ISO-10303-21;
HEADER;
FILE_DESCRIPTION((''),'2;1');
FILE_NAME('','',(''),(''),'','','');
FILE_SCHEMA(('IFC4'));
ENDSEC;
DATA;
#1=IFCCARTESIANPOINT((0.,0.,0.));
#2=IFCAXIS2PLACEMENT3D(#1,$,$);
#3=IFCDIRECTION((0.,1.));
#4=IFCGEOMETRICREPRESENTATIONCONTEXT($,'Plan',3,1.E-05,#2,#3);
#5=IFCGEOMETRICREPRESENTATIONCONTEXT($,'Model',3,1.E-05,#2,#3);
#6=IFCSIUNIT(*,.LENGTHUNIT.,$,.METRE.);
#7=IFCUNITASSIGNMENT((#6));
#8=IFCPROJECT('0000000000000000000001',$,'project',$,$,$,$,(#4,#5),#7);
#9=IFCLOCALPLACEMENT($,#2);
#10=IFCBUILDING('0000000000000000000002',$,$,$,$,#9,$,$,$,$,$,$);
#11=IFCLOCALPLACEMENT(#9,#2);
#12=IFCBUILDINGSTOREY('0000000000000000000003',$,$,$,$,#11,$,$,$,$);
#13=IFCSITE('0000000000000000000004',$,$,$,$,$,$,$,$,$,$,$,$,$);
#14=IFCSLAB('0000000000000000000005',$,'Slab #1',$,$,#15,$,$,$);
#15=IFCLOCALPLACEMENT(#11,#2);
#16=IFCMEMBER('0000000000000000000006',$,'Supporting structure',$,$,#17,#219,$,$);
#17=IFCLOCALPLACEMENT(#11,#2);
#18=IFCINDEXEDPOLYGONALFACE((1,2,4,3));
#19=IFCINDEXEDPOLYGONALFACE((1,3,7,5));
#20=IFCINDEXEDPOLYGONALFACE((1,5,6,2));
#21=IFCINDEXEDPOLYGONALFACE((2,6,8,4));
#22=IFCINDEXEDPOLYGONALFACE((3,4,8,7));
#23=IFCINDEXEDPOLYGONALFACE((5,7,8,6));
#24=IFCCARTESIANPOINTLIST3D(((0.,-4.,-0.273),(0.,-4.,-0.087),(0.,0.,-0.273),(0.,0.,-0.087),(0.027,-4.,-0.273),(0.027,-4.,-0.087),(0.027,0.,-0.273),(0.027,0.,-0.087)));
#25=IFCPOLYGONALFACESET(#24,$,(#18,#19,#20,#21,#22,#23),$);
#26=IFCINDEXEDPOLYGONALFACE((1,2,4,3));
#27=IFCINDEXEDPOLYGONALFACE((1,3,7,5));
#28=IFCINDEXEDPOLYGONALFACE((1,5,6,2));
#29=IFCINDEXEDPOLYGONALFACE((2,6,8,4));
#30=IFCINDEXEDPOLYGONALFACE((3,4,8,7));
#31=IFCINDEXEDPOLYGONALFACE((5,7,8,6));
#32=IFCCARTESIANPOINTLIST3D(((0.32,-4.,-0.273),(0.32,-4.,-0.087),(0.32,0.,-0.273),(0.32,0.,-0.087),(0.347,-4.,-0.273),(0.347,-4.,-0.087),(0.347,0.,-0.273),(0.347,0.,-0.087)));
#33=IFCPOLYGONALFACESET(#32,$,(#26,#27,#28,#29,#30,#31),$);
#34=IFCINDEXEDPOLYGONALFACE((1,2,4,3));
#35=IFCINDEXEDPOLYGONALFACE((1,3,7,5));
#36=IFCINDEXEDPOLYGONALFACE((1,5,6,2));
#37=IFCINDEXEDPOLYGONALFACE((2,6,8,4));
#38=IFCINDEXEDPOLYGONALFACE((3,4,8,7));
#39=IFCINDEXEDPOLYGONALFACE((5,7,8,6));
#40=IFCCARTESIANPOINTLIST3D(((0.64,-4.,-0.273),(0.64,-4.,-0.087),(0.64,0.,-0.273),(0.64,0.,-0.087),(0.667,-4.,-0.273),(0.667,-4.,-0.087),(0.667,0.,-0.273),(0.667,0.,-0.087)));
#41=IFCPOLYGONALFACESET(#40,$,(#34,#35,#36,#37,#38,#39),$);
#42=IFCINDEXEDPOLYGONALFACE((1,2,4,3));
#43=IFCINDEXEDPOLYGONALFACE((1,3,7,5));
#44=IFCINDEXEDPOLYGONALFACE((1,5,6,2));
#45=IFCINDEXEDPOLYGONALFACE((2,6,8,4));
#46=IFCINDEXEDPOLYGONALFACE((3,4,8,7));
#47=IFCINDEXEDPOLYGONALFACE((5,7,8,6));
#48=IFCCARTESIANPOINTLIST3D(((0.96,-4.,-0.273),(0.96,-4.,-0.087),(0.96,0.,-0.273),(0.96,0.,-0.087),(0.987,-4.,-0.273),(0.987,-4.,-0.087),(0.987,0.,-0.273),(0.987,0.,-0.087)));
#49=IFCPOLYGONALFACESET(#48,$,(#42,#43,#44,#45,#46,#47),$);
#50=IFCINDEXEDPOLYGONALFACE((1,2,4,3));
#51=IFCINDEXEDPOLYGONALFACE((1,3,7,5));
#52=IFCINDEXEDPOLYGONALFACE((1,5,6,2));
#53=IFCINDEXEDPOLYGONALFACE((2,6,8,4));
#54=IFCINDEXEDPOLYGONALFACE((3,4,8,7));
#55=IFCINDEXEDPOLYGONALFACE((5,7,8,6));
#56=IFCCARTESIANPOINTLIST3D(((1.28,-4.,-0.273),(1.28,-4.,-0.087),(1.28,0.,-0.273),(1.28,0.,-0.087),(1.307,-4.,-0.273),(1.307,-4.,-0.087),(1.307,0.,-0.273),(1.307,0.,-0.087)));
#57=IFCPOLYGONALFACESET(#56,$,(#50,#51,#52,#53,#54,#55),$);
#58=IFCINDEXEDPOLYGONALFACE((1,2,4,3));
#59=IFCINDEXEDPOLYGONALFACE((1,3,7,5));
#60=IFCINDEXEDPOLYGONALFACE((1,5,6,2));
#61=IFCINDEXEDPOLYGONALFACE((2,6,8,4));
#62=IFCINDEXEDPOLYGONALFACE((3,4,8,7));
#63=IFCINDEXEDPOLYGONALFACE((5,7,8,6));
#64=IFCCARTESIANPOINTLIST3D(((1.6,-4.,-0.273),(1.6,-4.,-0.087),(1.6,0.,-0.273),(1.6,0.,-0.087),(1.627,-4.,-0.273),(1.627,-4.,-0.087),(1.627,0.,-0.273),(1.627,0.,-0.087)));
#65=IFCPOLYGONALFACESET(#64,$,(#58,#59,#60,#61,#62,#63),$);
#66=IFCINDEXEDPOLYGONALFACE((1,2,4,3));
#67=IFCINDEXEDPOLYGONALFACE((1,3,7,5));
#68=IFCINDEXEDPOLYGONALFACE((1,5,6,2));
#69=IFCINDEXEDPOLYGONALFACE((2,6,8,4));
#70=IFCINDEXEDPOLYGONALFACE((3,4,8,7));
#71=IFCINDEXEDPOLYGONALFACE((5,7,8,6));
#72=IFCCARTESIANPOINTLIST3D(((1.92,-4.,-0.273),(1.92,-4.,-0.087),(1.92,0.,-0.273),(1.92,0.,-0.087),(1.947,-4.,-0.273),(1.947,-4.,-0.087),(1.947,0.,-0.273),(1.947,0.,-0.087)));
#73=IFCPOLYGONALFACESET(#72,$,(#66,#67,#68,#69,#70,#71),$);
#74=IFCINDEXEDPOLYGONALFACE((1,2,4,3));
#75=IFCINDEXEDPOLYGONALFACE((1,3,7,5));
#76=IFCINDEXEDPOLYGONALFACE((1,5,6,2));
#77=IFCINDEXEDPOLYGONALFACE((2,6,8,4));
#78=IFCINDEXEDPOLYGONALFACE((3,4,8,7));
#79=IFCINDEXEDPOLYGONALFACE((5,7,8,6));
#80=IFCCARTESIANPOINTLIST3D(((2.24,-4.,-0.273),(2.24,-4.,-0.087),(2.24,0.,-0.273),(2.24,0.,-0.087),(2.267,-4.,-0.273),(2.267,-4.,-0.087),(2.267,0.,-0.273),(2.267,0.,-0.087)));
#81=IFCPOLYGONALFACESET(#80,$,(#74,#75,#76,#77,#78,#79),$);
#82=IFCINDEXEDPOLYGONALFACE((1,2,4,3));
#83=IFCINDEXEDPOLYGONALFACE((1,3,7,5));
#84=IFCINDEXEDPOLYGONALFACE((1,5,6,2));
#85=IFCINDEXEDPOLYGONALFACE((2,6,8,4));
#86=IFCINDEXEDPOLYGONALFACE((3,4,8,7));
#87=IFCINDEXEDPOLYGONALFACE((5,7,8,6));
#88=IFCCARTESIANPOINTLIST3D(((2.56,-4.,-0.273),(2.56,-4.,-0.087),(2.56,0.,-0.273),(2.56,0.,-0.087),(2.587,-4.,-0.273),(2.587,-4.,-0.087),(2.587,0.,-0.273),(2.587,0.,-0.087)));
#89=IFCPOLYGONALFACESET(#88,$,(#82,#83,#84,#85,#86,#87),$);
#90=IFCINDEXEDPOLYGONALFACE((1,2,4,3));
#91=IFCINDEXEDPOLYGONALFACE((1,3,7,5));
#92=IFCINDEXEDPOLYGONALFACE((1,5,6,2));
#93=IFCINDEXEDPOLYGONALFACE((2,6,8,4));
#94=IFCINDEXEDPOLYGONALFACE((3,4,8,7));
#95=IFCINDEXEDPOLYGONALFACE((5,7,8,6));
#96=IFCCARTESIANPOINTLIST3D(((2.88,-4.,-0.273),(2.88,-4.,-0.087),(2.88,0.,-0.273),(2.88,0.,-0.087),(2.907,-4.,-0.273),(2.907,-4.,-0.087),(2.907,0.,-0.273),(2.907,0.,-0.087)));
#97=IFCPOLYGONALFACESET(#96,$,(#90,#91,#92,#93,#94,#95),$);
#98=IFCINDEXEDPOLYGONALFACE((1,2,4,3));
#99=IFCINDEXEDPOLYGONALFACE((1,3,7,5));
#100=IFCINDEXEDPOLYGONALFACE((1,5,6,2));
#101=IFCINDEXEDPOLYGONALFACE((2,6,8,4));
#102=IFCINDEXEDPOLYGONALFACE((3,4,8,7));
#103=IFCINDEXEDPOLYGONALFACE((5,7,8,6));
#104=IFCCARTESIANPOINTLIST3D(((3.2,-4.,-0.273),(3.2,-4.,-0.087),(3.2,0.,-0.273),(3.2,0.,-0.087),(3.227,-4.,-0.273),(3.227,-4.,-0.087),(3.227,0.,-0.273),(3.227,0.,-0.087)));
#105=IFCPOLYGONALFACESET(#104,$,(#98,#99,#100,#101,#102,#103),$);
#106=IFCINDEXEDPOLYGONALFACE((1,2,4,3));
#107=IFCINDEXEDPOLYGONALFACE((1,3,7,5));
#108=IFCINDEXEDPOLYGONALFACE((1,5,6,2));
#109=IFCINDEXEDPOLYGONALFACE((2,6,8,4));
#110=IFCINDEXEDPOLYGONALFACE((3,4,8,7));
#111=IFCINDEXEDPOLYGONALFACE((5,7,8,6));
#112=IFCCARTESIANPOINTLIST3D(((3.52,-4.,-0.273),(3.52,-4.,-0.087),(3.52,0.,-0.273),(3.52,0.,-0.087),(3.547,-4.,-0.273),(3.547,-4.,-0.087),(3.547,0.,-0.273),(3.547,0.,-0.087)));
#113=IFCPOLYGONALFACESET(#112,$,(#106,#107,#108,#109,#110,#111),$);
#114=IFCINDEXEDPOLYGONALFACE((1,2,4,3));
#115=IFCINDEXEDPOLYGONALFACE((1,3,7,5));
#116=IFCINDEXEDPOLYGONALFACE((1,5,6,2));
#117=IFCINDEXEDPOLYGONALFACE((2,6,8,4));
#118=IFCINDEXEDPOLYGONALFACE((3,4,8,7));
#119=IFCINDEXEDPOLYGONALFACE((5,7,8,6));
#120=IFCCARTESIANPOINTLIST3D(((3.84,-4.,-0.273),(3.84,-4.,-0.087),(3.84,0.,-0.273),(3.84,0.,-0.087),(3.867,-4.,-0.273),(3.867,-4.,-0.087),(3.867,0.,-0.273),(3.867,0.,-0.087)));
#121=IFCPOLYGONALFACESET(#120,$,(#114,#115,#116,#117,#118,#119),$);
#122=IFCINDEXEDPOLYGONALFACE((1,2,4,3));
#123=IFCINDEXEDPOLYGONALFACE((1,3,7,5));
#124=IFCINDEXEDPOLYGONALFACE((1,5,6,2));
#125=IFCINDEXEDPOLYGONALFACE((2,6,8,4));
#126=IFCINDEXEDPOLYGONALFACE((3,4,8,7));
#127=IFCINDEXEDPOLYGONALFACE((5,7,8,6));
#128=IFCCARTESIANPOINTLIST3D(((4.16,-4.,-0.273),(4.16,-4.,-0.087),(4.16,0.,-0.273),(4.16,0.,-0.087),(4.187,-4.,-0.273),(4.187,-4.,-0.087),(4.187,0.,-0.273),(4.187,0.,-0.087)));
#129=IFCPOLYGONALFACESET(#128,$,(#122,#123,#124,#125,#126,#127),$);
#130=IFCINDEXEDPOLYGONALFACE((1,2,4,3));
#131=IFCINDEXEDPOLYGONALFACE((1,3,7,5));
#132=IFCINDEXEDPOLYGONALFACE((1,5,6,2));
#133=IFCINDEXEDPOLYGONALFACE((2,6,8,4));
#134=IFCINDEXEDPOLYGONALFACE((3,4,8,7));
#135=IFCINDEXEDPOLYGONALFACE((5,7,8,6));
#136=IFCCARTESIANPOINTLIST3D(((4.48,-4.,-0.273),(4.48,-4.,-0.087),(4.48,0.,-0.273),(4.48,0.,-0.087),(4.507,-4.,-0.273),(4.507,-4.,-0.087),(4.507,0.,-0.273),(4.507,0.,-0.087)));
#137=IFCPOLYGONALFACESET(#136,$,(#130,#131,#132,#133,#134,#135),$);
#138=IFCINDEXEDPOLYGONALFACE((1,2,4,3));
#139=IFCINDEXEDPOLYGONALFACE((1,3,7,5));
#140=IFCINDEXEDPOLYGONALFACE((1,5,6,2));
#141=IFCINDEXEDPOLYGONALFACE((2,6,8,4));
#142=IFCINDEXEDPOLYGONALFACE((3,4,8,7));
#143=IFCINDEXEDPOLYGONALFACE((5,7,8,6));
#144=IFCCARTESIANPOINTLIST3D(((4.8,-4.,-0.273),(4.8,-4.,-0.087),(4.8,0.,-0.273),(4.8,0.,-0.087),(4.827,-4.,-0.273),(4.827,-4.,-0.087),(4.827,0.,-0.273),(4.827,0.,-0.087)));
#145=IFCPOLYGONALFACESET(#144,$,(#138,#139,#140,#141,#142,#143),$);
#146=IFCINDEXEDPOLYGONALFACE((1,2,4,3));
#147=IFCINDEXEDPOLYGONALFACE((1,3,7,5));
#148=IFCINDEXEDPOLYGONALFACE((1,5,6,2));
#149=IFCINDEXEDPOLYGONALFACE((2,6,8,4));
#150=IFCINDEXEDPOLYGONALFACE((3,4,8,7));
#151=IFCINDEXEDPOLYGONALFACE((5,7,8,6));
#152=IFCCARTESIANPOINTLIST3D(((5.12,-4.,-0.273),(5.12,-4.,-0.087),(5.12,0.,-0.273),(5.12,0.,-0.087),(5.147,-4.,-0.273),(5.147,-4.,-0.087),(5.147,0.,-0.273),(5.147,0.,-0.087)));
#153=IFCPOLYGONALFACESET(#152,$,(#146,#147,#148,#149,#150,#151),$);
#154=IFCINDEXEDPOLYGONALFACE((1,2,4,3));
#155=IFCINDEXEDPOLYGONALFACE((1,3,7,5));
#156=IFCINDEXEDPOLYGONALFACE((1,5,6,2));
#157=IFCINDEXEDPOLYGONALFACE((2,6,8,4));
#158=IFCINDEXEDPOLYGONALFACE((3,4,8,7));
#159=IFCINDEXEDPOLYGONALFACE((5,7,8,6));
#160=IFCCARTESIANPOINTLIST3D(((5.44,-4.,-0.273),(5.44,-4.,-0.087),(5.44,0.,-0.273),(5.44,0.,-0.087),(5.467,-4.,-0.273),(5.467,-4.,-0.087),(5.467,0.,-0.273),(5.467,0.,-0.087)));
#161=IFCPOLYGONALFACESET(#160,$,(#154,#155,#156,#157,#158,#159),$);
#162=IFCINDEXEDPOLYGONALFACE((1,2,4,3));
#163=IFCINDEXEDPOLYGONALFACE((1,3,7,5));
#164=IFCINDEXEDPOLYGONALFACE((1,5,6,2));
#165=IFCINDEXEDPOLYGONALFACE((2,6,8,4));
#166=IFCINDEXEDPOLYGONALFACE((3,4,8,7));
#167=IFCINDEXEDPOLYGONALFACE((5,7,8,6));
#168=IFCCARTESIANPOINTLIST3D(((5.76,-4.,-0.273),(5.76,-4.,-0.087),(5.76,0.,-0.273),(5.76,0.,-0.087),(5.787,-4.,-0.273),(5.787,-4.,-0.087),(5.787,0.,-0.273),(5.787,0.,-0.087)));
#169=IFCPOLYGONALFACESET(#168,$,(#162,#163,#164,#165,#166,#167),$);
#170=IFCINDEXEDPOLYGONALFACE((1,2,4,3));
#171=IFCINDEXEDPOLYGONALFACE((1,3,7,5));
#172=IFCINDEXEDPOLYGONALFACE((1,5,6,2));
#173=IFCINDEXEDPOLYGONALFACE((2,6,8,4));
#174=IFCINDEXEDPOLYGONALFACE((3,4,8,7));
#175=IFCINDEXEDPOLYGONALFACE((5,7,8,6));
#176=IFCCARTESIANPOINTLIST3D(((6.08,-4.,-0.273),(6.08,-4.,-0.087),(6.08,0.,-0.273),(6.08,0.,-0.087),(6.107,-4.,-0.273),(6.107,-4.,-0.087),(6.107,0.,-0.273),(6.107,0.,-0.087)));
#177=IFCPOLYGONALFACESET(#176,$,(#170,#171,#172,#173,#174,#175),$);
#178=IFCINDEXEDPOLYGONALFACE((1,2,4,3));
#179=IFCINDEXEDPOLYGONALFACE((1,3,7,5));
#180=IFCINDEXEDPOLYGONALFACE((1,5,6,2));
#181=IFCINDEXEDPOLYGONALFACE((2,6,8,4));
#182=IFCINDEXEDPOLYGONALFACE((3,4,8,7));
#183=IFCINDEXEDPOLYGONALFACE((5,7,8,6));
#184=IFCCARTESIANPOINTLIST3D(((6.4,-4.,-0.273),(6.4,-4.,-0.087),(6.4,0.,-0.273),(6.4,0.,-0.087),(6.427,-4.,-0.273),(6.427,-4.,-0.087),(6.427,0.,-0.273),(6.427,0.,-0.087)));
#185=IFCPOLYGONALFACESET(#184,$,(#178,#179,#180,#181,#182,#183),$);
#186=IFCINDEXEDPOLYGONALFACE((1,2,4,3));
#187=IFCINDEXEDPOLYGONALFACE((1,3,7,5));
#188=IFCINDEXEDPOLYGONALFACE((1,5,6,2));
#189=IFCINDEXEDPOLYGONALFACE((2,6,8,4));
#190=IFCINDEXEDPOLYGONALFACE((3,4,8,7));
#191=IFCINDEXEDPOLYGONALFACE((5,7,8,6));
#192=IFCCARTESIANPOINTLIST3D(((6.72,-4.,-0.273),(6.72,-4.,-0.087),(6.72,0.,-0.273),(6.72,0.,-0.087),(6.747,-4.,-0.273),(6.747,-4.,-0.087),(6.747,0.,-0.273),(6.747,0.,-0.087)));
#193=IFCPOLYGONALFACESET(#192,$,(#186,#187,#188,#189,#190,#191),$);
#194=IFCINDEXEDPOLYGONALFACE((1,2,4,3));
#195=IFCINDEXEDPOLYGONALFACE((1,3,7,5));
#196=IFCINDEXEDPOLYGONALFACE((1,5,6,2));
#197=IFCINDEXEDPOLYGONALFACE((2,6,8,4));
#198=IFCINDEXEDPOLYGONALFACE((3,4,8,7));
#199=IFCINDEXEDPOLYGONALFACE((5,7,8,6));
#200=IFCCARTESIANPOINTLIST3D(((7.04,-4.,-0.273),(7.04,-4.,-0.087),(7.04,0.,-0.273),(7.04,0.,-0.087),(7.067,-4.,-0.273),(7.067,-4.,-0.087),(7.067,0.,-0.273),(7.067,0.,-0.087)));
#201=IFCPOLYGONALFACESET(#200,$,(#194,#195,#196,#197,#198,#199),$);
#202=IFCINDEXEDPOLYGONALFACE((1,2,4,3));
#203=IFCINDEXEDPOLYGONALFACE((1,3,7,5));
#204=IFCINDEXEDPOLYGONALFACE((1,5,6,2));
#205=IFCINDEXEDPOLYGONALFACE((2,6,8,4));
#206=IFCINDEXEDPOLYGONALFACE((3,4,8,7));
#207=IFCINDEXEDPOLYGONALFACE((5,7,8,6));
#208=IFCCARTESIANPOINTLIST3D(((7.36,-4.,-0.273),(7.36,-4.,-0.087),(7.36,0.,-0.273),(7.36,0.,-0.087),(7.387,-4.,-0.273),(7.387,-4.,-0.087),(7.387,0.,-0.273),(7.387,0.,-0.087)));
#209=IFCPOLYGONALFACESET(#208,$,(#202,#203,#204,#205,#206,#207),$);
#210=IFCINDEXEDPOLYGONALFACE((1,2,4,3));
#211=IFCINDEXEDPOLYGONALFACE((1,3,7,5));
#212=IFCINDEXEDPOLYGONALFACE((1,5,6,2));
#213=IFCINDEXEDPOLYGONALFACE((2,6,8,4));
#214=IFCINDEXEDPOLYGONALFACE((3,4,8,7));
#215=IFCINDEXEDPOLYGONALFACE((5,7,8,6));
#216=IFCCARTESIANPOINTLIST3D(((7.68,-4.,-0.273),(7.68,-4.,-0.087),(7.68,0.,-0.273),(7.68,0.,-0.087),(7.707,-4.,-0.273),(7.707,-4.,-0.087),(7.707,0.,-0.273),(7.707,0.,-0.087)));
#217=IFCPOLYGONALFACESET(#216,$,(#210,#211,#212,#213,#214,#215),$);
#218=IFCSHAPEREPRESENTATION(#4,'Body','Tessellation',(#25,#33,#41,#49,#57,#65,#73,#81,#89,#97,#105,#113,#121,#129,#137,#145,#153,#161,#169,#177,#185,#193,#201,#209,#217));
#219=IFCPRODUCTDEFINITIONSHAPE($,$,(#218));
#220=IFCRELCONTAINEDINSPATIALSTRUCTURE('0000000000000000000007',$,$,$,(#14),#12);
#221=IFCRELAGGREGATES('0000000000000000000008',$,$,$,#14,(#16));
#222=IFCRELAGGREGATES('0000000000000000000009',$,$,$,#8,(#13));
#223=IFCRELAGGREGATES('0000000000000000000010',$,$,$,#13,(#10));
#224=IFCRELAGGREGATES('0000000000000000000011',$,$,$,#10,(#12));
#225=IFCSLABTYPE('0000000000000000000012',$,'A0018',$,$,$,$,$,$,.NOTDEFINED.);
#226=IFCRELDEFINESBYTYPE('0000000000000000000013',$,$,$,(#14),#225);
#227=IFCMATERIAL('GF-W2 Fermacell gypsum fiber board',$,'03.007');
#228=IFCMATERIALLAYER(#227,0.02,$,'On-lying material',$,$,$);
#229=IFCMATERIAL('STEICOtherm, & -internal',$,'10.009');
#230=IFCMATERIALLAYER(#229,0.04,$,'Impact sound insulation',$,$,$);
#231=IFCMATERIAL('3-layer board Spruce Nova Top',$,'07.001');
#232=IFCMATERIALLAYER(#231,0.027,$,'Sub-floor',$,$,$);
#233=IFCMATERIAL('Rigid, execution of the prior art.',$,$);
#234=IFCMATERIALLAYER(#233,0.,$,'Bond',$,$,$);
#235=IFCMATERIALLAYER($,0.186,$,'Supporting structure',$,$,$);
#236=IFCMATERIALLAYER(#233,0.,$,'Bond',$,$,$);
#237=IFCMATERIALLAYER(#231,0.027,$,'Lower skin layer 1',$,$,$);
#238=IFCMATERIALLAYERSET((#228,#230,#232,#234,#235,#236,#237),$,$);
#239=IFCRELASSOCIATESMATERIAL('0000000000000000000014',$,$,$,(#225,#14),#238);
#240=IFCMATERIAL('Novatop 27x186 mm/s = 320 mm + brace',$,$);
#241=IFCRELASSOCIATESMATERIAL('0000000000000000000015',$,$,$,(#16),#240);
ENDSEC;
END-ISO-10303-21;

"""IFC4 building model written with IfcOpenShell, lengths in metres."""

from ifc_helpers import new_model, si_unit, direction, frame, frame_2d, origin, place, context, project, spatial, rectangle, extrude, material, layer, layer_set, type_object, element, aggregate, save


model = new_model("IFC4")

# Units and contexts
plan_context = context("Plan", 3, precision=1e-05, world=origin(), true_north=direction((0.0, 1.0)))
model_context = context("Model", 3, precision=1e-05, world=origin(), true_north=direction((0.0, 1.0)))
ifc_project = project(units=[si_unit("LENGTHUNIT", "METRE")], contexts=[plan_context, model_context])

# Site, building, storey
site = spatial("IfcSite", under=ifc_project)
building_placement = place(None, origin())
building = spatial("IfcBuilding", under=site, at=building_placement)
storey_placement = place(building_placement, origin())
storey = spatial("IfcBuildingStorey", under=building, at=storey_placement)

# Slab, member
ifc_material_1 = material(Name="GF-W2 Fermacell gypsum fiber board", Category="03.007")
ifc_layer_1 = layer(ifc_material_1, 0.02, Name="On-lying material")
ifc_material_2 = material(Name="STEICOtherm, & -internal", Category="10.009")
ifc_layer_2 = layer(ifc_material_2, 0.04, Name="Impact sound insulation")
ifc_material_3 = material(Name="3-layer board Spruce Nova Top", Category="07.001")
ifc_layer_3 = layer(ifc_material_3, 0.027, Name="Sub-floor")
ifc_material_4 = material(Name="Rigid, execution of the prior art.")
ifc_layer_4 = layer(ifc_material_4, 0.0, Name="Bond")
ifc_layer_5 = layer(None, 0.186, Name="Supporting structure")
ifc_layer_6 = layer(ifc_material_4, 0.0, Name="Bond")
ifc_layer_7 = layer(ifc_material_3, 0.027, Name="Lower skin layer 1")
ifc_layer_set = layer_set([ifc_layer_1, ifc_layer_2, ifc_layer_3, ifc_layer_4, ifc_layer_5, ifc_layer_6, ifc_layer_7])
slab_type = type_object("IfcSlabType", Name="A0018", PredefinedType="NOTDEFINED", material=ifc_layer_set)
slab_placement = place(None, frame((0.0, 0.0, 0.0), z_axis=(0.0, 0.0, -1.0), x_axis=(1.0, 0.0, 0.0)))
slab = element("IfcSlab", 1, at=slab_placement, inside=storey, type_object=slab_type, material=ifc_layer_set, Name="Slab #1")
ifc_material_5 = material(Name="Novatop 27x186 mm/s = 320 mm + brace")
member_1_placement = place(slab_placement, origin())
member_1 = element("IfcMember", 2, at=member_1_placement, material=ifc_material_5, Name="Supporting structure", context=plan_context, shape_type="SweptSolid", body=[
    extrude(rectangle(XDim=0.027, YDim=0.186, at=frame_2d((0.0135, 0.093), x_axis=(1.0, 0.0))), frame((0.0, 4.0, 0.087), z_axis=(0.0, -1.0, 0.0), x_axis=(1.0, 0.0, 0.0)), (0.0, 0.0, 1.0), 4.0),
    extrude(rectangle(XDim=0.027, YDim=0.186, at=frame_2d((0.0135, 0.093), x_axis=(1.0, 0.0))), frame((0.32, 4.0, 0.087), z_axis=(0.0, -1.0, 0.0), x_axis=(1.0, 0.0, 0.0)), (0.0, 0.0, 1.0), 4.0),
    extrude(rectangle(XDim=0.027, YDim=0.186, at=frame_2d((0.0135, 0.093), x_axis=(1.0, 0.0))), frame((0.64, 4.0, 0.087), z_axis=(0.0, -1.0, 0.0), x_axis=(1.0, 0.0, 0.0)), (0.0, 0.0, 1.0), 4.0),
    extrude(rectangle(XDim=0.027, YDim=0.186, at=frame_2d((0.0135, 0.093), x_axis=(1.0, 0.0))), frame((0.96, 4.0, 0.087), z_axis=(0.0, -1.0, 0.0), x_axis=(1.0, 0.0, 0.0)), (0.0, 0.0, 1.0), 4.0),
    extrude(rectangle(XDim=0.027, YDim=0.186, at=frame_2d((0.0135, 0.093), x_axis=(1.0, 0.0))), frame((1.28, 4.0, 0.087), z_axis=(0.0, -1.0, 0.0), x_axis=(1.0, 0.0, 0.0)), (0.0, 0.0, 1.0), 4.0),
    extrude(rectangle(XDim=0.027, YDim=0.186, at=frame_2d((0.0135, 0.093), x_axis=(1.0, 0.0))), frame((1.6, 4.0, 0.087), z_axis=(0.0, -1.0, 0.0), x_axis=(1.0, 0.0, 0.0)), (0.0, 0.0, 1.0), 4.0),
    extrude(rectangle(XDim=0.027, YDim=0.186, at=frame_2d((0.0135, 0.093), x_axis=(1.0, 0.0))), frame((1.92, 4.0, 0.087), z_axis=(0.0, -1.0, 0.0), x_axis=(1.0, 0.0, 0.0)), (0.0, 0.0, 1.0), 4.0),
    extrude(rectangle(XDim=0.027, YDim=0.186, at=frame_2d((0.0135, 0.093), x_axis=(1.0, 0.0))), frame((2.24, 4.0, 0.087), z_axis=(0.0, -1.0, 0.0), x_axis=(1.0, 0.0, 0.0)), (0.0, 0.0, 1.0), 4.0),
    extrude(rectangle(XDim=0.027, YDim=0.186, at=frame_2d((0.0135, 0.093), x_axis=(1.0, 0.0))), frame((2.56, 4.0, 0.087), z_axis=(0.0, -1.0, 0.0), x_axis=(1.0, 0.0, 0.0)), (0.0, 0.0, 1.0), 4.0),
    extrude(rectangle(XDim=0.027, YDim=0.186, at=frame_2d((0.0135, 0.093), x_axis=(1.0, 0.0))), frame((2.88, 4.0, 0.087), z_axis=(0.0, -1.0, 0.0), x_axis=(1.0, 0.0, 0.0)), (0.0, 0.0, 1.0), 4.0),
    extrude(rectangle(XDim=0.027, YDim=0.186, at=frame_2d((0.0135, 0.093), x_axis=(1.0, 0.0))), frame((3.2, 4.0, 0.087), z_axis=(0.0, -1.0, 0.0), x_axis=(1.0, 0.0, 0.0)), (0.0, 0.0, 1.0), 4.0),
    extrude(rectangle(XDim=0.027, YDim=0.186, at=frame_2d((0.0135, 0.093), x_axis=(1.0, 0.0))), frame((3.52, 4.0, 0.087), z_axis=(0.0, -1.0, 0.0), x_axis=(1.0, 0.0, 0.0)), (0.0, 0.0, 1.0), 4.0),
    extrude(rectangle(XDim=0.027, YDim=0.186, at=frame_2d((0.0135, 0.093), x_axis=(1.0, 0.0))), frame((3.84, 4.0, 0.087), z_axis=(0.0, -1.0, 0.0), x_axis=(1.0, 0.0, 0.0)), (0.0, 0.0, 1.0), 4.0),
    extrude(rectangle(XDim=0.027, YDim=0.186, at=frame_2d((0.0135, 0.093), x_axis=(1.0, 0.0))), frame((4.16, 4.0, 0.087), z_axis=(0.0, -1.0, 0.0), x_axis=(1.0, 0.0, 0.0)), (0.0, 0.0, 1.0), 4.0),
    extrude(rectangle(XDim=0.027, YDim=0.186, at=frame_2d((0.0135, 0.093), x_axis=(1.0, 0.0))), frame((4.48, 4.0, 0.087), z_axis=(0.0, -1.0, 0.0), x_axis=(1.0, 0.0, 0.0)), (0.0, 0.0, 1.0), 4.0),
    extrude(rectangle(XDim=0.027, YDim=0.186, at=frame_2d((0.0135, 0.093), x_axis=(1.0, 0.0))), frame((4.8, 4.0, 0.087), z_axis=(0.0, -1.0, 0.0), x_axis=(1.0, 0.0, 0.0)), (0.0, 0.0, 1.0), 4.0),
    extrude(rectangle(XDim=0.027, YDim=0.186, at=frame_2d((0.0135, 0.093), x_axis=(1.0, 0.0))), frame((5.12, 4.0, 0.087), z_axis=(0.0, -1.0, 0.0), x_axis=(1.0, 0.0, 0.0)), (0.0, 0.0, 1.0), 4.0),
    extrude(rectangle(XDim=0.027, YDim=0.186, at=frame_2d((0.0135, 0.093), x_axis=(1.0, 0.0))), frame((5.44, 4.0, 0.087), z_axis=(0.0, -1.0, 0.0), x_axis=(1.0, 0.0, 0.0)), (0.0, 0.0, 1.0), 4.0),
    extrude(rectangle(XDim=0.027, YDim=0.186, at=frame_2d((0.0135, 0.093), x_axis=(1.0, 0.0))), frame((5.76, 4.0, 0.087), z_axis=(0.0, -1.0, 0.0), x_axis=(1.0, 0.0, 0.0)), (0.0, 0.0, 1.0), 4.0),
    extrude(rectangle(XDim=0.027, YDim=0.186, at=frame_2d((0.0135, 0.093), x_axis=(1.0, 0.0))), frame((6.08, 4.0, 0.087), z_axis=(0.0, -1.0, 0.0), x_axis=(1.0, 0.0, 0.0)), (0.0, 0.0, 1.0), 4.0),
    extrude(rectangle(XDim=0.027, YDim=0.186, at=frame_2d((0.0135, 0.093), x_axis=(1.0, 0.0))), frame((6.4, 4.0, 0.087), z_axis=(0.0, -1.0, 0.0), x_axis=(1.0, 0.0, 0.0)), (0.0, 0.0, 1.0), 4.0),
    extrude(rectangle(XDim=0.027, YDim=0.186, at=frame_2d((0.0135, 0.093), x_axis=(1.0, 0.0))), frame((6.72, 4.0, 0.087), z_axis=(0.0, -1.0, 0.0), x_axis=(1.0, 0.0, 0.0)), (0.0, 0.0, 1.0), 4.0),
    extrude(rectangle(XDim=0.027, YDim=0.186, at=frame_2d((0.0135, 0.093), x_axis=(1.0, 0.0))), frame((7.04, 4.0, 0.087), z_axis=(0.0, -1.0, 0.0), x_axis=(1.0, 0.0, 0.0)), (0.0, 0.0, 1.0), 4.0),
    extrude(rectangle(XDim=0.027, YDim=0.186, at=frame_2d((0.0135, 0.093), x_axis=(1.0, 0.0))), frame((7.36, 4.0, 0.087), z_axis=(0.0, -1.0, 0.0), x_axis=(1.0, 0.0, 0.0)), (0.0, 0.0, 1.0), 4.0),
    extrude(rectangle(XDim=0.027, YDim=0.186, at=frame_2d((0.0135, 0.093), x_axis=(1.0, 0.0))), frame((7.68, 4.0, 0.087), z_axis=(0.0, -1.0, 0.0), x_axis=(1.0, 0.0, 0.0)), (0.0, 0.0, 1.0), 4.0),
])
aggregate(slab, [member_1])

save(model, "model.ifc")
